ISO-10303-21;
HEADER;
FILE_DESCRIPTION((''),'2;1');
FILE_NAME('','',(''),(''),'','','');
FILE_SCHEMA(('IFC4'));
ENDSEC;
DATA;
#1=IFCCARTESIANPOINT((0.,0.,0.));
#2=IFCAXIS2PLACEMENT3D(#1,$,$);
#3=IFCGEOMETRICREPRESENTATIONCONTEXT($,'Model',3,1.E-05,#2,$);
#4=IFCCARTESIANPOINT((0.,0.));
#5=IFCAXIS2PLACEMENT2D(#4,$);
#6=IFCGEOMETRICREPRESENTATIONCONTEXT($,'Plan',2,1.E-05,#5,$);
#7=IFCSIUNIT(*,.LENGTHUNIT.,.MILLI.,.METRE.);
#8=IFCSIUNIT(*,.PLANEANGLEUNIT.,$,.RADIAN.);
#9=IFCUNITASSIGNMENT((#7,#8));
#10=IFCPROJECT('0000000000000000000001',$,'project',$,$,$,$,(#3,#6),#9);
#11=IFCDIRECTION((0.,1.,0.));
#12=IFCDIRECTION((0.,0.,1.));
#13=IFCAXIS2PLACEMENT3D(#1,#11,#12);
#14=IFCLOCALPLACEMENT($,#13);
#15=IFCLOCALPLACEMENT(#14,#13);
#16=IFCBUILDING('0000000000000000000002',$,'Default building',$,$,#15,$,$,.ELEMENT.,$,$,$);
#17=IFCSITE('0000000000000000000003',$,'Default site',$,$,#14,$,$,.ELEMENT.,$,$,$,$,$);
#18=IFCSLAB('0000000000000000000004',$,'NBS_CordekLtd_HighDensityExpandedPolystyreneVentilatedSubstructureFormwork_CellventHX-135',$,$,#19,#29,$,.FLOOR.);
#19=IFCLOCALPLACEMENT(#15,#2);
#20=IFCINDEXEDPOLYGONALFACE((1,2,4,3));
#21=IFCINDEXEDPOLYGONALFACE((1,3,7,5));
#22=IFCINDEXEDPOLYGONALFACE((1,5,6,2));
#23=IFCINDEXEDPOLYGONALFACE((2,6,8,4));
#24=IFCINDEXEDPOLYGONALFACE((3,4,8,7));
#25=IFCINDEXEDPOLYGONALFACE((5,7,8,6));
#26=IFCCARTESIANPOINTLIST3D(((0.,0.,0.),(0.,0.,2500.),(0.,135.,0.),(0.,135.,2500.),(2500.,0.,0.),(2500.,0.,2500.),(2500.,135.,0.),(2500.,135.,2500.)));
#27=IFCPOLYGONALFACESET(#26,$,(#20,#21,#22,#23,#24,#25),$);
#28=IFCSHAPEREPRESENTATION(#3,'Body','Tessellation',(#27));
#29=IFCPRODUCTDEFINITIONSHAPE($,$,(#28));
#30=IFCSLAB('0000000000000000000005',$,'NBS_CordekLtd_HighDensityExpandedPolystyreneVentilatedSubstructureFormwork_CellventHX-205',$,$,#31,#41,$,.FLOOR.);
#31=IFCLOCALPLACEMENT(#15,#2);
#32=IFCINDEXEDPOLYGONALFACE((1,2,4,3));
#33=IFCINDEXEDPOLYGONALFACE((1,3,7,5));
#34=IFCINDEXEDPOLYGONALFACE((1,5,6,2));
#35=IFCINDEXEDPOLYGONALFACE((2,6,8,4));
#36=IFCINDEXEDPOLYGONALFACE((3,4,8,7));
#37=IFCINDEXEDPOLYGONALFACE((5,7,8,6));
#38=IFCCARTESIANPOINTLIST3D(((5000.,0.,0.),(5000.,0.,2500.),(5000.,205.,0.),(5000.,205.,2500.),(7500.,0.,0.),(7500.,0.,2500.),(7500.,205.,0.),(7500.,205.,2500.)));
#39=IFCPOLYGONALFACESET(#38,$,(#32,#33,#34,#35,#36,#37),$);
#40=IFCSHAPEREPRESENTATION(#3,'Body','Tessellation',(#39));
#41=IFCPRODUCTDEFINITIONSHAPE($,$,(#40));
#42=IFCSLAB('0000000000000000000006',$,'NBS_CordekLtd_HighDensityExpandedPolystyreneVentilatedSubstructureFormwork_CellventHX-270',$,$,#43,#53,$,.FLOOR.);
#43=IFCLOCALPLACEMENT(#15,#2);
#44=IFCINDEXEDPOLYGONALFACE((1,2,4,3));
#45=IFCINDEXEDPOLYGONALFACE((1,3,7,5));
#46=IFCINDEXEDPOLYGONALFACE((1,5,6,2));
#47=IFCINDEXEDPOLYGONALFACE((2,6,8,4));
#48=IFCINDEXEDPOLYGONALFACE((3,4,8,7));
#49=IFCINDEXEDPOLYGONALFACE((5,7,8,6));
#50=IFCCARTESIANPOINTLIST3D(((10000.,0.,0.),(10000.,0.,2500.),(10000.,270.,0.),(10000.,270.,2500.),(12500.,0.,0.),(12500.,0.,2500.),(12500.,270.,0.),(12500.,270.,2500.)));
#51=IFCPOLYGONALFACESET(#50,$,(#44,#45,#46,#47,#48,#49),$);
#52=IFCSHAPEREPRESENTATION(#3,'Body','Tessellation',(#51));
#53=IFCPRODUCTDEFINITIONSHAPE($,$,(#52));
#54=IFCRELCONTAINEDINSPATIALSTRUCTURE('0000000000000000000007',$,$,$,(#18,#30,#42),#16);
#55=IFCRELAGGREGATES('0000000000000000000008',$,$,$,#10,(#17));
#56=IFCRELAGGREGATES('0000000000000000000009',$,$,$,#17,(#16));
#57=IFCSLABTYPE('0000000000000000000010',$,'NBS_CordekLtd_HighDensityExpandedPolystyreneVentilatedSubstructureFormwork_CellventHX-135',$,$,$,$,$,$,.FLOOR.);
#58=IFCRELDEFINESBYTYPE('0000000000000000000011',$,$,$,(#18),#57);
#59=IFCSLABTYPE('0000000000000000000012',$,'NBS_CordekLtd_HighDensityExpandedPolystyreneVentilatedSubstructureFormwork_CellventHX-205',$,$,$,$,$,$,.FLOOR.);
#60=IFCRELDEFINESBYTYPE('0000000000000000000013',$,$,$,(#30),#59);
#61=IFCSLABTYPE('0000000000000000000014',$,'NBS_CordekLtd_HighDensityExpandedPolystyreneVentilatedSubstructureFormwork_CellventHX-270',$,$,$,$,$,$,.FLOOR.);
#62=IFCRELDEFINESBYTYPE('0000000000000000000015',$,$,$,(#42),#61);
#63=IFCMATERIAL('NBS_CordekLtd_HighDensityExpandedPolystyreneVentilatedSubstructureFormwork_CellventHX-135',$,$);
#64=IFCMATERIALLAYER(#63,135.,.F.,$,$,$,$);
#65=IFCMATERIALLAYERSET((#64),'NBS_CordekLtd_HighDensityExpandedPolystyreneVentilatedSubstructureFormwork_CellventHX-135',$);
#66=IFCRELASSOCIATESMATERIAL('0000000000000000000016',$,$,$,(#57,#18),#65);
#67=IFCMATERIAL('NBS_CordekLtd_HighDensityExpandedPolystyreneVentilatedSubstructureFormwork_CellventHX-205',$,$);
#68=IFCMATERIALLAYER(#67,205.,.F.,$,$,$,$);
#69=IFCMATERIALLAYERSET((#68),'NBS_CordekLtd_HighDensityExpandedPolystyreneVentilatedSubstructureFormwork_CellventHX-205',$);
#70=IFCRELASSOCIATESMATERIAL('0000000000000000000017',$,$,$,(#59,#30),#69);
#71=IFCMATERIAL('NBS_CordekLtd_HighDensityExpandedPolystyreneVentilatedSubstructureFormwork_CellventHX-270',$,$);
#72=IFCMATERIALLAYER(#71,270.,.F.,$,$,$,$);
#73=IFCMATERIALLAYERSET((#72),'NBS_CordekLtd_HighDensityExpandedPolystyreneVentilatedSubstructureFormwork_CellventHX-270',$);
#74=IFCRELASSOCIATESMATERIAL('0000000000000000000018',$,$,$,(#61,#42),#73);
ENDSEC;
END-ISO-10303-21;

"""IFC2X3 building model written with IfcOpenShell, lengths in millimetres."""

from ifc_helpers import new_model, si_unit, frame, frame_2d, origin, origin_with_axes, origin_2d, place, context, project, spatial, rectangle, extrude, material, layer, layer_set, layer_usage, type_object, element, save


model = new_model("IFC2X3")

# Units and contexts
model_context = context("Model", 3, precision=1e-05, world=origin())
plan_context = context("Plan", 2, precision=1e-05, world=origin_2d())
ifc_project = project(units=[si_unit("LENGTHUNIT", "METRE", prefix="MILLI"), si_unit("PLANEANGLEUNIT", "RADIAN")], contexts=[model_context, plan_context])

# Site, building
site_placement = place(None, frame((0.0, 0.0, 0.0), z_axis=(0.0, 1.0, 0.0), x_axis=(0.0, 0.0, 1.0)))
site = spatial("IfcSite", under=ifc_project, at=site_placement, Name="Default site", CompositionType="ELEMENT")
building_placement = place(site_placement, frame((0.0, 0.0, 0.0), z_axis=(0.0, 1.0, 0.0), x_axis=(0.0, 0.0, 1.0)))
building = spatial("IfcBuilding", under=site, at=building_placement, Name="Default building", CompositionType="ELEMENT")

# Slabs
ifc_material_1 = material(Name="NBS_CordekLtd_HighDensityExpandedPolystyreneVentilatedSubstructureFormwork_CellventHX-135")
ifc_layer_1 = layer(ifc_material_1, 135.0, ventilated=False)
ifc_layer_set_1 = layer_set([ifc_layer_1], Name="NBS_CordekLtd_HighDensityExpandedPolystyreneVentilatedSubstructureFormwork_CellventHX-135")
ifc_layer_usage_1 = layer_usage(ifc_layer_set_1, "AXIS3", "NEGATIVE", 0.0)
slab_type_1 = type_object("IfcSlabType", Name="NBS_CordekLtd_HighDensityExpandedPolystyreneVentilatedSubstructureFormwork_CellventHX-135", PredefinedType="FLOOR", material=ifc_layer_set_1)
slab_1_placement = place(None, origin())
element("IfcSlab", 1, at=slab_1_placement, inside=building, type_object=slab_type_1, material=ifc_layer_usage_1, Name="NBS_CordekLtd_HighDensityExpandedPolystyreneVentilatedSubstructureFormwork_CellventHX-135", PredefinedType="FLOOR", context=model_context, shape_type="SweptSolid", body=[
    extrude(rectangle(XDim=2500.0, YDim=2500.0, at=frame_2d((1250.0, 1250.0))), origin_with_axes(), (0.0, 0.0, 1.0), 135.0),
])
ifc_material_2 = material(Name="NBS_CordekLtd_HighDensityExpandedPolystyreneVentilatedSubstructureFormwork_CellventHX-205")
ifc_layer_2 = layer(ifc_material_2, 205.0, ventilated=False)
ifc_layer_set_2 = layer_set([ifc_layer_2], Name="NBS_CordekLtd_HighDensityExpandedPolystyreneVentilatedSubstructureFormwork_CellventHX-205")
ifc_layer_usage_2 = layer_usage(ifc_layer_set_2, "AXIS3", "NEGATIVE", 0.0)
slab_type_2 = type_object("IfcSlabType", Name="NBS_CordekLtd_HighDensityExpandedPolystyreneVentilatedSubstructureFormwork_CellventHX-205", PredefinedType="FLOOR", material=ifc_layer_set_2)
slab_2_placement = place(None, frame((0.0, 5000.0, 0.0)))
element("IfcSlab", 2, at=slab_2_placement, inside=building, type_object=slab_type_2, material=ifc_layer_usage_2, Name="NBS_CordekLtd_HighDensityExpandedPolystyreneVentilatedSubstructureFormwork_CellventHX-205", PredefinedType="FLOOR", context=model_context, shape_type="SweptSolid", body=[
    extrude(rectangle(XDim=2500.0, YDim=2500.0, at=frame_2d((1250.0, 1250.0))), origin_with_axes(), (0.0, 0.0, 1.0), 205.0),
])
ifc_material_3 = material(Name="NBS_CordekLtd_HighDensityExpandedPolystyreneVentilatedSubstructureFormwork_CellventHX-270")
ifc_layer_3 = layer(ifc_material_3, 270.0, ventilated=False)
ifc_layer_set_3 = layer_set([ifc_layer_3], Name="NBS_CordekLtd_HighDensityExpandedPolystyreneVentilatedSubstructureFormwork_CellventHX-270")
ifc_layer_usage_3 = layer_usage(ifc_layer_set_3, "AXIS3", "NEGATIVE", 0.0)
slab_type_3 = type_object("IfcSlabType", Name="NBS_CordekLtd_HighDensityExpandedPolystyreneVentilatedSubstructureFormwork_CellventHX-270", PredefinedType="FLOOR", material=ifc_layer_set_3)
slab_3_placement = place(None, frame((0.0, 10000.0, 0.0)))
element("IfcSlab", 3, at=slab_3_placement, inside=building, type_object=slab_type_3, material=ifc_layer_usage_3, Name="NBS_CordekLtd_HighDensityExpandedPolystyreneVentilatedSubstructureFormwork_CellventHX-270", PredefinedType="FLOOR", context=model_context, shape_type="SweptSolid", body=[
    extrude(rectangle(XDim=2500.0, YDim=2500.0, at=frame_2d((1250.0, 1250.0))), origin_with_axes(), (0.0, 0.0, 1.0), 270.0),
])

save(model, "model.ifc")
